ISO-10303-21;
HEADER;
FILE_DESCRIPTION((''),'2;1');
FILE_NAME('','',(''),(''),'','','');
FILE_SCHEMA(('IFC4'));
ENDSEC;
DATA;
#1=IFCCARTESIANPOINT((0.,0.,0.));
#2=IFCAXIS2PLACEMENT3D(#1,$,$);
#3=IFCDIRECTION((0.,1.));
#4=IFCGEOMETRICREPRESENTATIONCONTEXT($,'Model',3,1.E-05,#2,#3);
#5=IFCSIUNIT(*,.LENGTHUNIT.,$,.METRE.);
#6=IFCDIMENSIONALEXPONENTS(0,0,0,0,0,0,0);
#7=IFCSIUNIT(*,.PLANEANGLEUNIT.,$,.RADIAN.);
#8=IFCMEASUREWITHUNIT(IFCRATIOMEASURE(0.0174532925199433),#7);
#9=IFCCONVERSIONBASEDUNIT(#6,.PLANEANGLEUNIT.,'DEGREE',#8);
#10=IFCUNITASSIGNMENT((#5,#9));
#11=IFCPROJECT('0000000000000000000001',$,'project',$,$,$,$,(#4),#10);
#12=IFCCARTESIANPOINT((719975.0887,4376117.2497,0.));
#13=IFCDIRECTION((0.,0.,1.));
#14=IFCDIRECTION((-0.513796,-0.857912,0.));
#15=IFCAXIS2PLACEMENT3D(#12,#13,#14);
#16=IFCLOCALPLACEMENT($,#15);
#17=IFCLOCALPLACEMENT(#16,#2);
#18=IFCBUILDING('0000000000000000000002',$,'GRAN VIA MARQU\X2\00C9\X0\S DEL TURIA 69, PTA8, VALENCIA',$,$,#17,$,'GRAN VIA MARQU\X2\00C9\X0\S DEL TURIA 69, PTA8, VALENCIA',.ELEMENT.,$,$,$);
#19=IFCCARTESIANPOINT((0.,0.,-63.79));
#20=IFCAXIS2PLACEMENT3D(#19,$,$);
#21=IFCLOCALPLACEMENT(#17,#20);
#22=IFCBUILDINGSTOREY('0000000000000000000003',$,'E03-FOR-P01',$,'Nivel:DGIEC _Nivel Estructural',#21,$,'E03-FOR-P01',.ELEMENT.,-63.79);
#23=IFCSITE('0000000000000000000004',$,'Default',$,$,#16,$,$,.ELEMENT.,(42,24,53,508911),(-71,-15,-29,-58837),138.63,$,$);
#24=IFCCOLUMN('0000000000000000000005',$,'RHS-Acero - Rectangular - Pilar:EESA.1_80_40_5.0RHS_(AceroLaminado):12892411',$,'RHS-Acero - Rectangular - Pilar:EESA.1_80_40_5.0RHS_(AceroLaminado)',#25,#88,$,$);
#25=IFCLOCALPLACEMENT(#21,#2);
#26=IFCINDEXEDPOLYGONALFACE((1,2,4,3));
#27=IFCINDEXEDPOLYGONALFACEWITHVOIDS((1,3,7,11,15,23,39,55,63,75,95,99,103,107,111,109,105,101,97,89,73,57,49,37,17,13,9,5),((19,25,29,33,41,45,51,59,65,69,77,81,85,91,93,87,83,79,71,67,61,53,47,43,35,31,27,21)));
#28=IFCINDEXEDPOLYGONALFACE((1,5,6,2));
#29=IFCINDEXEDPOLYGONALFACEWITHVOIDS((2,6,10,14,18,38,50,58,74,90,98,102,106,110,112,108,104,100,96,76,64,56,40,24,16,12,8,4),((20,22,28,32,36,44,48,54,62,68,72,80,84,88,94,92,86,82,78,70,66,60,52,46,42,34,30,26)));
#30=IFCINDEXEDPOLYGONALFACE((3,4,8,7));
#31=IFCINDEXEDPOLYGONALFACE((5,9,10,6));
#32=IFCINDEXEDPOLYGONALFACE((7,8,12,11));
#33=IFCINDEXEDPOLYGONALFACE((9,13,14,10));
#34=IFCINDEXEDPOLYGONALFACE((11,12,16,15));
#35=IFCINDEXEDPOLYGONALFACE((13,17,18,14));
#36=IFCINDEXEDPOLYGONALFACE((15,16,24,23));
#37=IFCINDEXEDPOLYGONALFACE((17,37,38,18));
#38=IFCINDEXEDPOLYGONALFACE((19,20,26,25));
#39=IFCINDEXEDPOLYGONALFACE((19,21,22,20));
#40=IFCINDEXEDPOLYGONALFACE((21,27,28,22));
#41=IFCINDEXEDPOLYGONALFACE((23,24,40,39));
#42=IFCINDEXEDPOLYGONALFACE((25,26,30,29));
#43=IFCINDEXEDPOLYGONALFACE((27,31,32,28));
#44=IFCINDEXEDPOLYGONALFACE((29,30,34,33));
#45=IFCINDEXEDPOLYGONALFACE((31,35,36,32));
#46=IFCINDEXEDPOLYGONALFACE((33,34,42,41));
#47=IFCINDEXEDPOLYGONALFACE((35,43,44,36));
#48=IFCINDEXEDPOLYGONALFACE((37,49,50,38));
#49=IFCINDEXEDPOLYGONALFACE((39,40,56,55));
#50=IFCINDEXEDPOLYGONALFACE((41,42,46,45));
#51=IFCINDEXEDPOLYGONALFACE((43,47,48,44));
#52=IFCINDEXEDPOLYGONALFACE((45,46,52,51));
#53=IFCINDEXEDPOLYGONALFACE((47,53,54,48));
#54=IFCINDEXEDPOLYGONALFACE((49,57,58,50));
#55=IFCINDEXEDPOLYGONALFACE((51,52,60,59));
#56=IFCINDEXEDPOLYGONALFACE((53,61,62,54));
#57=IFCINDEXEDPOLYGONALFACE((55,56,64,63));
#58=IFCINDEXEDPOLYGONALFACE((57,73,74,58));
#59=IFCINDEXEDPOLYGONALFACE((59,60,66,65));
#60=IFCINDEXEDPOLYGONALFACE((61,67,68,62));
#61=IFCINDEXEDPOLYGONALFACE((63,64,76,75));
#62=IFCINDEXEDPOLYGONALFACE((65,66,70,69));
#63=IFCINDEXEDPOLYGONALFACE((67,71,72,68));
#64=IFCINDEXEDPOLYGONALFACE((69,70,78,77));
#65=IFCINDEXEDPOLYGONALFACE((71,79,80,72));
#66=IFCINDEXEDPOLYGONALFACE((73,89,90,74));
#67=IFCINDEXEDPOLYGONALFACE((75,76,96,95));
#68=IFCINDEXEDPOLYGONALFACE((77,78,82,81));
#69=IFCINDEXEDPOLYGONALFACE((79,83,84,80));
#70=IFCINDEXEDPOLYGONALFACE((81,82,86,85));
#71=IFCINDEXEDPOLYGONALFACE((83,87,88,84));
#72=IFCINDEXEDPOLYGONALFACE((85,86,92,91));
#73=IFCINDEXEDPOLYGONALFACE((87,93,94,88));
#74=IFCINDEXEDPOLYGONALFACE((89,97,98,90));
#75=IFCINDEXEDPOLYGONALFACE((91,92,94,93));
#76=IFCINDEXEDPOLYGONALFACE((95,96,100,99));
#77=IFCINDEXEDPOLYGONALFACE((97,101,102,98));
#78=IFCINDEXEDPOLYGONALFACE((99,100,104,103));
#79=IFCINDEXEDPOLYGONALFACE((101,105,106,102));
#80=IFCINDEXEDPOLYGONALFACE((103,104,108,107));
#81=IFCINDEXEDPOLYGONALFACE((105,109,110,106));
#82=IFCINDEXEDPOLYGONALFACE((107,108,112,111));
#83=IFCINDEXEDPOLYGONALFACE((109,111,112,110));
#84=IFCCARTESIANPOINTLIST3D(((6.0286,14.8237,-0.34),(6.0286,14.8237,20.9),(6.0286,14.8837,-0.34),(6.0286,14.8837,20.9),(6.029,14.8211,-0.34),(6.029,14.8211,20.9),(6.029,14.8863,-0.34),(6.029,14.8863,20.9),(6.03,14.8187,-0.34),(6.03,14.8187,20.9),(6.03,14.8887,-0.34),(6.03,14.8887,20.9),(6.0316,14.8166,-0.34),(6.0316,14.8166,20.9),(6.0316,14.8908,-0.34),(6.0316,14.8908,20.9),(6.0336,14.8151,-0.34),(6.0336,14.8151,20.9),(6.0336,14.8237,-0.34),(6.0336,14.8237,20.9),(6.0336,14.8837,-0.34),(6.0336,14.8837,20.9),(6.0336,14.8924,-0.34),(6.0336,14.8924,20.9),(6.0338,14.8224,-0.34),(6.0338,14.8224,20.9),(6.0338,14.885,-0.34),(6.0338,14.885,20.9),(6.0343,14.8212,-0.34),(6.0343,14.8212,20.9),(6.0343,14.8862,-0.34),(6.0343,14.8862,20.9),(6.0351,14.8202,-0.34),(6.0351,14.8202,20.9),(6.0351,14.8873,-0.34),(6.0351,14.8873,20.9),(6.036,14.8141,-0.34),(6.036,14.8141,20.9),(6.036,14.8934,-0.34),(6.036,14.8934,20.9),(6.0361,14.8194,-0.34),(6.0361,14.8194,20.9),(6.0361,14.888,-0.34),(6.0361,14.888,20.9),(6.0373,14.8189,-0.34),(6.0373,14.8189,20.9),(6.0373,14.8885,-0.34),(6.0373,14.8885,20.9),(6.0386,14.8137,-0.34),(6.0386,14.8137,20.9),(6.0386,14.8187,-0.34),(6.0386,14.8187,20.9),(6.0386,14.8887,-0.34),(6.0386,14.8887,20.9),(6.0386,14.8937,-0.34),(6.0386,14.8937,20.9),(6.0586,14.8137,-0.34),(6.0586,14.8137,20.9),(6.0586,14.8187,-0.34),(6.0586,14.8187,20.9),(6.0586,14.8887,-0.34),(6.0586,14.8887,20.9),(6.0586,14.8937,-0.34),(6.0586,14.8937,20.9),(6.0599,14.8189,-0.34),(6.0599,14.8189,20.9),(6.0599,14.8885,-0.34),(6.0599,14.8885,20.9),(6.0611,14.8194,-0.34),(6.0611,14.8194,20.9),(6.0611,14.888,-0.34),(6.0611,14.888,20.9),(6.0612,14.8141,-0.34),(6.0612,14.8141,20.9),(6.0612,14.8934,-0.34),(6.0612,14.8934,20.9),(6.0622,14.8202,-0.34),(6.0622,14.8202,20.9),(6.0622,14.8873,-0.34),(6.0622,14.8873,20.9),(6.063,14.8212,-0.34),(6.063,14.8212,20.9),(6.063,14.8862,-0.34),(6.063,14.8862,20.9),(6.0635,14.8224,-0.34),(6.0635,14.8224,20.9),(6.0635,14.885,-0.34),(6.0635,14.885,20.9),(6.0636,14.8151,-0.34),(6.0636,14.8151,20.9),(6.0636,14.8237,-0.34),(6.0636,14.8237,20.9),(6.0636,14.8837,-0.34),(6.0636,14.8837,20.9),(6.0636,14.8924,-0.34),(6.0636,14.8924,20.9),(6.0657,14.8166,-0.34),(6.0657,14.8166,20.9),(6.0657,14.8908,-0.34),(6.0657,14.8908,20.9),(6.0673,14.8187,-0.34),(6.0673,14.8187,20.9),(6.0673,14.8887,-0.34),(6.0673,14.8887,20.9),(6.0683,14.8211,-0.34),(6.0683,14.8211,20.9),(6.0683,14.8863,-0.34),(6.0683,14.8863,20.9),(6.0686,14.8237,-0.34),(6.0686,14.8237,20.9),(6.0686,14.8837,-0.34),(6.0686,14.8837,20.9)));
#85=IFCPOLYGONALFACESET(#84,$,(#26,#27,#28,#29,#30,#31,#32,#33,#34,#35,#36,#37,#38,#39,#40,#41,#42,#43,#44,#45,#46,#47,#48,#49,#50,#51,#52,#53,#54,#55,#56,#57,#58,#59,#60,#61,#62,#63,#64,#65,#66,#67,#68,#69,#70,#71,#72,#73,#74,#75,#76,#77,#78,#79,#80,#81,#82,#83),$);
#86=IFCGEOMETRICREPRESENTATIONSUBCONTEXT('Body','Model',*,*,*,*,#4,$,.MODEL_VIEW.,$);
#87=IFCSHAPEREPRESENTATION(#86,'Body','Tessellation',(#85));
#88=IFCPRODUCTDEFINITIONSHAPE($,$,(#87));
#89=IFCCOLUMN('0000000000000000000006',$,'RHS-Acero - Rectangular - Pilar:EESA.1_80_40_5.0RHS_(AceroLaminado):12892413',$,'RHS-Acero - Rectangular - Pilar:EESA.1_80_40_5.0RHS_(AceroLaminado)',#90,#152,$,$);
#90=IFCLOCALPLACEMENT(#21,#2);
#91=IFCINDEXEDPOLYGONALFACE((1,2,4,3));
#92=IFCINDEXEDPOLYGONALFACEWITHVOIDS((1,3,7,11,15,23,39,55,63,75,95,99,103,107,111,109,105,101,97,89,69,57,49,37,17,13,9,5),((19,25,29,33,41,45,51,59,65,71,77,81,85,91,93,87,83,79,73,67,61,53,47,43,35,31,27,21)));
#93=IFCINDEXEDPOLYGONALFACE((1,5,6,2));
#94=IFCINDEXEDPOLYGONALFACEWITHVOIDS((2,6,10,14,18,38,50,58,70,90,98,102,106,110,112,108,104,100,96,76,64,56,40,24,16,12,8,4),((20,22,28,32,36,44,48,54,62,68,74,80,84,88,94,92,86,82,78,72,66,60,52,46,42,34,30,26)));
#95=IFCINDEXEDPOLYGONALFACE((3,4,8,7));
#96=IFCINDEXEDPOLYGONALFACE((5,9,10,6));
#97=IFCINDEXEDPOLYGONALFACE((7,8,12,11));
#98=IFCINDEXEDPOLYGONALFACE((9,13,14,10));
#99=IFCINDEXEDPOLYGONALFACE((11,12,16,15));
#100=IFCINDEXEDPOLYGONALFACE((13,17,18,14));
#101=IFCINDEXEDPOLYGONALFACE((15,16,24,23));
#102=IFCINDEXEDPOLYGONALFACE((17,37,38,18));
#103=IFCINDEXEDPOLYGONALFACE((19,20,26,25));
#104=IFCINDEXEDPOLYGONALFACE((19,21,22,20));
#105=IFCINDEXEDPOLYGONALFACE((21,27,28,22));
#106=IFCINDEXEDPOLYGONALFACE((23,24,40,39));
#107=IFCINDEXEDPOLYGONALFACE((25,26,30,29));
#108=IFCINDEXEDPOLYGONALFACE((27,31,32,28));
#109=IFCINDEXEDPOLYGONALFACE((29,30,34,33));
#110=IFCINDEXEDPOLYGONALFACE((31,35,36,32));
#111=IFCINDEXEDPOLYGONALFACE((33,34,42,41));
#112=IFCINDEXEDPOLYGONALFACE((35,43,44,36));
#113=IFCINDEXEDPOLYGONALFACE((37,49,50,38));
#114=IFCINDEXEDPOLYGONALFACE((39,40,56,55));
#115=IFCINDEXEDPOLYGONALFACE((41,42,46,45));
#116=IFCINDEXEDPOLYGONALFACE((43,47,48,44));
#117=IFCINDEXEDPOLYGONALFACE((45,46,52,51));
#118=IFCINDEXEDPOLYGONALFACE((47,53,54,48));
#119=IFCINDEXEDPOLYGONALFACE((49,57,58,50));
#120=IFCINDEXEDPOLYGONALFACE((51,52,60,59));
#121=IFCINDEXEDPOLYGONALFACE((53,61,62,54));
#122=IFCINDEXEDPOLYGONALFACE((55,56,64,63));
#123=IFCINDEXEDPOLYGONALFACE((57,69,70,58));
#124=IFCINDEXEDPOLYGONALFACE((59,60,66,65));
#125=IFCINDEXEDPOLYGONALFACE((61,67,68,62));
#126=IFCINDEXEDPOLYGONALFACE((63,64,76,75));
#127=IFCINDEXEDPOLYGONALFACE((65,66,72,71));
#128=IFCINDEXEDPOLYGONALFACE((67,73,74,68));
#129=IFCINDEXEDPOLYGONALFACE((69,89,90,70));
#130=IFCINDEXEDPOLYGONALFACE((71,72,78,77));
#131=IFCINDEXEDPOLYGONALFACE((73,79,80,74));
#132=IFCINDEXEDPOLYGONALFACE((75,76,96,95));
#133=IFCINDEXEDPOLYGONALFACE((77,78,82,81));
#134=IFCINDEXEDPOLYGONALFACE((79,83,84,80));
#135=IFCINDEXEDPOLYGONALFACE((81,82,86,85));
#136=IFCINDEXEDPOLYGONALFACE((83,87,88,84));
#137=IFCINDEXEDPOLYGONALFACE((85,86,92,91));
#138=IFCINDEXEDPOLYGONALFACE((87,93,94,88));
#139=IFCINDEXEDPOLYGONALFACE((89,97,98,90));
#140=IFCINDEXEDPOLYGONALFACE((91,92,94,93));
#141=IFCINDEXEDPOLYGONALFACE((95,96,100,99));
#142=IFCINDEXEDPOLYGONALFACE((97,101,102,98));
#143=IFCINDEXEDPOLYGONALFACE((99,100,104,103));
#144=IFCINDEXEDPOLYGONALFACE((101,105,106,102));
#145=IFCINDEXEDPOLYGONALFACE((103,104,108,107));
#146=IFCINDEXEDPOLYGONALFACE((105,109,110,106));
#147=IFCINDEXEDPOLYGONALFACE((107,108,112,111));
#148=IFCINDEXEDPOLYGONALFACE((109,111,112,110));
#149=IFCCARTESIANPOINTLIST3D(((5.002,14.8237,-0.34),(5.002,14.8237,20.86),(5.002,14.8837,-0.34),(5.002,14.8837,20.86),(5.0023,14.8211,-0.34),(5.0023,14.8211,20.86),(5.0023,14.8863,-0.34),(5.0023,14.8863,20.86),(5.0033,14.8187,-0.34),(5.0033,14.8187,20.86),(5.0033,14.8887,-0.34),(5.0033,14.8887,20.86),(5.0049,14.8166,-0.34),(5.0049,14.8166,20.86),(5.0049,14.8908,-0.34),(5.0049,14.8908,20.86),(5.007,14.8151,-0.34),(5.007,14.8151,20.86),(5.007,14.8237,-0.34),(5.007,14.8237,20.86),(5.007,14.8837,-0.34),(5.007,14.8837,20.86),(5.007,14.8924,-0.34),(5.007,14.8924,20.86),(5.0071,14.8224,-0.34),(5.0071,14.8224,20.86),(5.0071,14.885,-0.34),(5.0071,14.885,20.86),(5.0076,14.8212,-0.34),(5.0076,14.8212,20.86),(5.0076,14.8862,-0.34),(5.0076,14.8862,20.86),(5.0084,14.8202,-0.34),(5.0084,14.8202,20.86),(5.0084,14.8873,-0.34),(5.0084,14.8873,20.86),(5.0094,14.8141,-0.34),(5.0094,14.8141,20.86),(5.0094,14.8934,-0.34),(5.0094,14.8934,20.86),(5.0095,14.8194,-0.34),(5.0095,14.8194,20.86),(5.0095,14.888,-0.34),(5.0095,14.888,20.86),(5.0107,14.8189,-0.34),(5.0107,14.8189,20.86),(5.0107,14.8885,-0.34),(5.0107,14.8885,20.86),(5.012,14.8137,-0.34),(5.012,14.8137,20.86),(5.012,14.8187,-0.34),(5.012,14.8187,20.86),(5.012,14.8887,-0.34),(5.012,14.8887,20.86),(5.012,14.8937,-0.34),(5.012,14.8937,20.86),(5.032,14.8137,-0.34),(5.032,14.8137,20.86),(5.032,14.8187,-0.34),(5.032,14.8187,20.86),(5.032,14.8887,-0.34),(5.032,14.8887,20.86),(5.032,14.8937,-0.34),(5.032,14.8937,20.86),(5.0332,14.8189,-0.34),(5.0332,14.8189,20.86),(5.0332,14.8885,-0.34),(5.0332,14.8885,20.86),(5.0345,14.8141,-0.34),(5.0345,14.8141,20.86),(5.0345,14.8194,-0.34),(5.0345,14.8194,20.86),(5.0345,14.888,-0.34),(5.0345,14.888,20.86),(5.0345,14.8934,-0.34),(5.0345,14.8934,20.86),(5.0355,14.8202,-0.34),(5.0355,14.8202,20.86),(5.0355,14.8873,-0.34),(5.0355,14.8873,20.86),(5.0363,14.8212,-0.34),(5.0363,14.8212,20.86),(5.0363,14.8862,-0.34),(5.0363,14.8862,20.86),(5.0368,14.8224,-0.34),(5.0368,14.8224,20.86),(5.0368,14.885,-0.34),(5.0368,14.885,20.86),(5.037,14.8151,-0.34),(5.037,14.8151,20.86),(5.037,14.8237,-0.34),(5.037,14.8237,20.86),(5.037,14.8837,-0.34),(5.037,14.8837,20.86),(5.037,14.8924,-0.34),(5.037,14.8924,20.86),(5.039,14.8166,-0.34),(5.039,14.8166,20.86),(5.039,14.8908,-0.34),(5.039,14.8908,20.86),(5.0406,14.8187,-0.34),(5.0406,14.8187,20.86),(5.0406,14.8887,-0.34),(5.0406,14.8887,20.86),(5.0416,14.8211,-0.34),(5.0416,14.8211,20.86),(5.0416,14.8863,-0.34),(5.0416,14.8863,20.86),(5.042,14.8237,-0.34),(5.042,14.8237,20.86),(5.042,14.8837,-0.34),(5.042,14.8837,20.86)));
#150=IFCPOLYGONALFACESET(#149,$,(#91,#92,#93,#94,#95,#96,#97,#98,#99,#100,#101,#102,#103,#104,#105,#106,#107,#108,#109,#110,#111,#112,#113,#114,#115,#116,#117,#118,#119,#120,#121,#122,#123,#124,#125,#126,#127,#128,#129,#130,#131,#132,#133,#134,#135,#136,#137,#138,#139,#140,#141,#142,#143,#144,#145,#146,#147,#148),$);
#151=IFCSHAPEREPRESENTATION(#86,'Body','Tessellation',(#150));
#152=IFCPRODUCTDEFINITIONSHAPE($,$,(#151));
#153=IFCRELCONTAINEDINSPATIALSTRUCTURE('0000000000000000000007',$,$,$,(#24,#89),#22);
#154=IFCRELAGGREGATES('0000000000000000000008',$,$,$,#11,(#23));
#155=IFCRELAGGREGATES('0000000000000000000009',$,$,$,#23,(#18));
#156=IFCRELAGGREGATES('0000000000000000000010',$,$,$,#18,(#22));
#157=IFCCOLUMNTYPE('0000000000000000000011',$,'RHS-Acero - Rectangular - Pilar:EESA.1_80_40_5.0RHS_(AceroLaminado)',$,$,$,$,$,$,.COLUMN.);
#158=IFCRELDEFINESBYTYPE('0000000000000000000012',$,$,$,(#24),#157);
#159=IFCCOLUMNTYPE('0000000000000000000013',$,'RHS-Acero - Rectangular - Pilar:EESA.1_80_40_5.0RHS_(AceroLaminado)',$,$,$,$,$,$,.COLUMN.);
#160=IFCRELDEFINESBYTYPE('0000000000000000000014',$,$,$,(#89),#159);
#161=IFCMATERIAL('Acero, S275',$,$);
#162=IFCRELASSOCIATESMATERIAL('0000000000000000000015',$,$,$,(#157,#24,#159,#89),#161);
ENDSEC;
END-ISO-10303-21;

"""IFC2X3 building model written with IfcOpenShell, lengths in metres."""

from ifc_helpers import new_model, entity, si_unit, converted_unit, direction, frame, frame_2d, origin, place, context, subcontext, project, spatial, polyline, circle_curve, parameter, trimmed, segment, composite_curve, outline, extrude, source, transform, mapped, material, type_object, type_shapes, element, save


model = new_model("IFC2X3")

# Units and contexts
model_context = context("Model", 3, precision=1e-05, world=origin(), true_north=direction((0.0, 1.0)))
body_context = subcontext(model_context, "Body", "Model", "MODEL_VIEW")
ifc_project = project(units=[si_unit("LENGTHUNIT", "METRE"), converted_unit("PLANEANGLEUNIT", "DEGREE", entity("IfcRatioMeasure", 0.0174532925199433), si_unit("PLANEANGLEUNIT", "RADIAN"), dimensions=[0, 0, 0, 0, 0, 0, 0])], contexts=[model_context])

# Site, building, storey
site_placement = place(None, frame((719975.0887, 4376117.2497, 0.0), z_axis=(0.0, 0.0, 1.0), x_axis=(-0.513796, -0.857912, 0.0)))
site = spatial("IfcSite", under=ifc_project, at=site_placement, Name="Default", CompositionType="ELEMENT", RefLatitude=(42, 24, 53, 508911), RefLongitude=(-71, -15, -29, -58837), RefElevation=138.63)
building_placement = place(site_placement, origin())
building = spatial("IfcBuilding", under=site, at=building_placement, Name="GRAN VIA MARQUÉS DEL TURIA 69, PTA8, VALENCIA", LongName="GRAN VIA MARQUÉS DEL TURIA 69, PTA8, VALENCIA", CompositionType="ELEMENT")
storey_placement = place(building_placement, frame((0.0, 0.0, -63.79)))
storey = spatial("IfcBuildingStorey", under=building, at=storey_placement, Name="E03-FOR-P01", ObjectType="Nivel:DGIEC _Nivel Estructural", LongName="E03-FOR-P01", CompositionType="ELEMENT", Elevation=-63.79)

# Columns
ifc_material_1 = material(Name="Acero, S275")
column_type_1 = type_object("IfcColumnType", Name="RHS-Acero - Rectangular - Pilar:EESA.1_80_40_5.0RHS_(AceroLaminado)", PredefinedType="COLUMN", material=ifc_material_1)
shared_shape_1 = source(origin(), body_context, "Body", "SweptSolid", [
    extrude(outline(composite_curve([segment(polyline([(-0.01, -0.04), (0.01, -0.04)]), True, "CONTINUOUS"), segment(trimmed(circle_curve(frame_2d((0.01, -0.03), x_axis=(-1.0, 0.0)), 0.01), [parameter(90.0)], [parameter(180.0)], True, "PARAMETER"), True, "CONTINUOUS"), segment(polyline([(0.02, -0.03), (0.02, 0.03)]), True, "CONTINUOUS"), segment(trimmed(circle_curve(frame_2d((0.01, 0.03), x_axis=(-1.0, 0.0)), 0.01), [parameter(180.0)], [parameter(270.0)], True, "PARAMETER"), True, "CONTINUOUS"), segment(polyline([(0.01, 0.04), (-0.01, 0.04)]), True, "CONTINUOUS"), segment(trimmed(circle_curve(frame_2d((-0.01, 0.03), x_axis=(-1.0, 0.0)), 0.01), [parameter(270.0)], [parameter(360.0)], True, "PARAMETER"), True, "CONTINUOUS"), segment(polyline([(-0.02, 0.03), (-0.02, -0.03)]), True, "CONTINUOUS"), segment(trimmed(circle_curve(frame_2d((-0.01, -0.03), x_axis=(-1.0, 0.0)), 0.01), [parameter(360.0)], [parameter(90.0)], True, "PARAMETER"), True, "CONTINUOUS")], self_intersect=False), holes=[composite_curve([segment(trimmed(circle_curve(frame_2d((-0.01, -0.03), x_axis=(-1.0, 0.0)), 0.005), [parameter(0.0)], [parameter(90.0)], True, "PARAMETER"), False, "CONTINUOUS"), segment(polyline([(-0.015, -0.03), (-0.015, 0.03)]), True, "CONTINUOUS"), segment(trimmed(circle_curve(frame_2d((-0.01, 0.03), x_axis=(-1.0, 0.0)), 0.005), [parameter(270.0)], [parameter(0.0)], True, "PARAMETER"), False, "CONTINUOUS"), segment(polyline([(-0.01, 0.035), (0.01, 0.035)]), True, "CONTINUOUS"), segment(trimmed(circle_curve(frame_2d((0.01, 0.03), x_axis=(-1.0, 0.0)), 0.005), [parameter(180.0)], [parameter(270.0)], True, "PARAMETER"), False, "CONTINUOUS"), segment(polyline([(0.015, 0.03), (0.015, -0.03)]), True, "CONTINUOUS"), segment(trimmed(circle_curve(frame_2d((0.01, -0.03), x_axis=(-1.0, 0.0)), 0.005), [parameter(90.0)], [parameter(180.0)], True, "PARAMETER"), False, "CONTINUOUS"), segment(polyline([(0.01, -0.035), (-0.01, -0.035)]), True, "CONTINUOUS")], self_intersect=False)]), frame((0.0, 0.0, -64.13), z_axis=(0.0, 0.0, 1.0), x_axis=(-1.0, 0.0, 0.0)), (0.0, 0.0, 1.0), 21.24),
])
type_shapes(column_type_1, [shared_shape_1])
column_placement = place(storey_placement, frame((6.0486, 14.8537, 63.79), z_axis=(0.0, 0.0, 1.0), x_axis=(-1.0, 0.0, 0.0)))
element("IfcColumn", 1, at=column_placement, inside=storey, type_object=column_type_1, material=ifc_material_1, Name="RHS-Acero - Rectangular - Pilar:EESA.1_80_40_5.0RHS_(AceroLaminado):12892411", ObjectType="RHS-Acero - Rectangular - Pilar:EESA.1_80_40_5.0RHS_(AceroLaminado)", context=body_context, shape_type="MappedRepresentation", body=[
    mapped(shared_shape_1, transform((0.0, 0.0, 0.0), scale=1.0)),
])
column_type_2 = type_object("IfcColumnType", Name="RHS-Acero - Rectangular - Pilar:EESA.1_80_40_5.0RHS_(AceroLaminado)", PredefinedType="COLUMN", material=ifc_material_1)
shared_shape_2 = source(origin(), body_context, "Body", "SweptSolid", [
    extrude(outline(composite_curve([segment(polyline([(-0.01, -0.04), (0.01, -0.04)]), True, "CONTINUOUS"), segment(trimmed(circle_curve(frame_2d((0.01, -0.03), x_axis=(-1.0, 0.0)), 0.01), [parameter(90.0)], [parameter(180.0)], True, "PARAMETER"), True, "CONTINUOUS"), segment(polyline([(0.02, -0.03), (0.02, 0.03)]), True, "CONTINUOUS"), segment(trimmed(circle_curve(frame_2d((0.01, 0.03), x_axis=(-1.0, 0.0)), 0.01), [parameter(180.0)], [parameter(270.0)], True, "PARAMETER"), True, "CONTINUOUS"), segment(polyline([(0.01, 0.04), (-0.01, 0.04)]), True, "CONTINUOUS"), segment(trimmed(circle_curve(frame_2d((-0.01, 0.03), x_axis=(-1.0, 0.0)), 0.01), [parameter(270.0)], [parameter(360.0)], True, "PARAMETER"), True, "CONTINUOUS"), segment(polyline([(-0.02, 0.03), (-0.02, -0.03)]), True, "CONTINUOUS"), segment(trimmed(circle_curve(frame_2d((-0.01, -0.03), x_axis=(-1.0, 0.0)), 0.01), [parameter(360.0)], [parameter(90.0)], True, "PARAMETER"), True, "CONTINUOUS")], self_intersect=False), holes=[composite_curve([segment(trimmed(circle_curve(frame_2d((-0.01, -0.03), x_axis=(-1.0, 0.0)), 0.005), [parameter(0.0)], [parameter(90.0)], True, "PARAMETER"), False, "CONTINUOUS"), segment(polyline([(-0.015, -0.03), (-0.015, 0.03)]), True, "CONTINUOUS"), segment(trimmed(circle_curve(frame_2d((-0.01, 0.03), x_axis=(-1.0, 0.0)), 0.005), [parameter(270.0)], [parameter(0.0)], True, "PARAMETER"), False, "CONTINUOUS"), segment(polyline([(-0.01, 0.035), (0.01, 0.035)]), True, "CONTINUOUS"), segment(trimmed(circle_curve(frame_2d((0.01, 0.03), x_axis=(-1.0, 0.0)), 0.005), [parameter(180.0)], [parameter(270.0)], True, "PARAMETER"), False, "CONTINUOUS"), segment(polyline([(0.015, 0.03), (0.015, -0.03)]), True, "CONTINUOUS"), segment(trimmed(circle_curve(frame_2d((0.01, -0.03), x_axis=(-1.0, 0.0)), 0.005), [parameter(90.0)], [parameter(180.0)], True, "PARAMETER"), False, "CONTINUOUS"), segment(polyline([(0.01, -0.035), (-0.01, -0.035)]), True, "CONTINUOUS")], self_intersect=False)]), frame((0.0, 0.0, -64.13), z_axis=(0.0, 0.0, 1.0), x_axis=(-1.0, 0.0, 0.0)), (0.0, 0.0, 1.0), 21.2),
])
type_shapes(column_type_2, [shared_shape_2])
for number, where, z_axis, x_axis, name in (
    (2, (5.022, 14.8537, 63.79), (0.0, 0.0, 1.0), (-1.0, 0.0, 0.0), "RHS-Acero - Rectangular - Pilar:EESA.1_80_40_5.0RHS_(AceroLaminado):12892413"),
):
    element("IfcColumn", number, at=place(storey_placement, frame(where, z_axis=z_axis, x_axis=x_axis)), inside=storey, type_object=column_type_2, material=ifc_material_1, Name=name, ObjectType="RHS-Acero - Rectangular - Pilar:EESA.1_80_40_5.0RHS_(AceroLaminado)", context=body_context, shape_type="MappedRepresentation", body=[
        mapped(shared_shape_2, transform((0.0, 0.0, 0.0), scale=1.0)),
    ])

save(model, "model.ifc")
